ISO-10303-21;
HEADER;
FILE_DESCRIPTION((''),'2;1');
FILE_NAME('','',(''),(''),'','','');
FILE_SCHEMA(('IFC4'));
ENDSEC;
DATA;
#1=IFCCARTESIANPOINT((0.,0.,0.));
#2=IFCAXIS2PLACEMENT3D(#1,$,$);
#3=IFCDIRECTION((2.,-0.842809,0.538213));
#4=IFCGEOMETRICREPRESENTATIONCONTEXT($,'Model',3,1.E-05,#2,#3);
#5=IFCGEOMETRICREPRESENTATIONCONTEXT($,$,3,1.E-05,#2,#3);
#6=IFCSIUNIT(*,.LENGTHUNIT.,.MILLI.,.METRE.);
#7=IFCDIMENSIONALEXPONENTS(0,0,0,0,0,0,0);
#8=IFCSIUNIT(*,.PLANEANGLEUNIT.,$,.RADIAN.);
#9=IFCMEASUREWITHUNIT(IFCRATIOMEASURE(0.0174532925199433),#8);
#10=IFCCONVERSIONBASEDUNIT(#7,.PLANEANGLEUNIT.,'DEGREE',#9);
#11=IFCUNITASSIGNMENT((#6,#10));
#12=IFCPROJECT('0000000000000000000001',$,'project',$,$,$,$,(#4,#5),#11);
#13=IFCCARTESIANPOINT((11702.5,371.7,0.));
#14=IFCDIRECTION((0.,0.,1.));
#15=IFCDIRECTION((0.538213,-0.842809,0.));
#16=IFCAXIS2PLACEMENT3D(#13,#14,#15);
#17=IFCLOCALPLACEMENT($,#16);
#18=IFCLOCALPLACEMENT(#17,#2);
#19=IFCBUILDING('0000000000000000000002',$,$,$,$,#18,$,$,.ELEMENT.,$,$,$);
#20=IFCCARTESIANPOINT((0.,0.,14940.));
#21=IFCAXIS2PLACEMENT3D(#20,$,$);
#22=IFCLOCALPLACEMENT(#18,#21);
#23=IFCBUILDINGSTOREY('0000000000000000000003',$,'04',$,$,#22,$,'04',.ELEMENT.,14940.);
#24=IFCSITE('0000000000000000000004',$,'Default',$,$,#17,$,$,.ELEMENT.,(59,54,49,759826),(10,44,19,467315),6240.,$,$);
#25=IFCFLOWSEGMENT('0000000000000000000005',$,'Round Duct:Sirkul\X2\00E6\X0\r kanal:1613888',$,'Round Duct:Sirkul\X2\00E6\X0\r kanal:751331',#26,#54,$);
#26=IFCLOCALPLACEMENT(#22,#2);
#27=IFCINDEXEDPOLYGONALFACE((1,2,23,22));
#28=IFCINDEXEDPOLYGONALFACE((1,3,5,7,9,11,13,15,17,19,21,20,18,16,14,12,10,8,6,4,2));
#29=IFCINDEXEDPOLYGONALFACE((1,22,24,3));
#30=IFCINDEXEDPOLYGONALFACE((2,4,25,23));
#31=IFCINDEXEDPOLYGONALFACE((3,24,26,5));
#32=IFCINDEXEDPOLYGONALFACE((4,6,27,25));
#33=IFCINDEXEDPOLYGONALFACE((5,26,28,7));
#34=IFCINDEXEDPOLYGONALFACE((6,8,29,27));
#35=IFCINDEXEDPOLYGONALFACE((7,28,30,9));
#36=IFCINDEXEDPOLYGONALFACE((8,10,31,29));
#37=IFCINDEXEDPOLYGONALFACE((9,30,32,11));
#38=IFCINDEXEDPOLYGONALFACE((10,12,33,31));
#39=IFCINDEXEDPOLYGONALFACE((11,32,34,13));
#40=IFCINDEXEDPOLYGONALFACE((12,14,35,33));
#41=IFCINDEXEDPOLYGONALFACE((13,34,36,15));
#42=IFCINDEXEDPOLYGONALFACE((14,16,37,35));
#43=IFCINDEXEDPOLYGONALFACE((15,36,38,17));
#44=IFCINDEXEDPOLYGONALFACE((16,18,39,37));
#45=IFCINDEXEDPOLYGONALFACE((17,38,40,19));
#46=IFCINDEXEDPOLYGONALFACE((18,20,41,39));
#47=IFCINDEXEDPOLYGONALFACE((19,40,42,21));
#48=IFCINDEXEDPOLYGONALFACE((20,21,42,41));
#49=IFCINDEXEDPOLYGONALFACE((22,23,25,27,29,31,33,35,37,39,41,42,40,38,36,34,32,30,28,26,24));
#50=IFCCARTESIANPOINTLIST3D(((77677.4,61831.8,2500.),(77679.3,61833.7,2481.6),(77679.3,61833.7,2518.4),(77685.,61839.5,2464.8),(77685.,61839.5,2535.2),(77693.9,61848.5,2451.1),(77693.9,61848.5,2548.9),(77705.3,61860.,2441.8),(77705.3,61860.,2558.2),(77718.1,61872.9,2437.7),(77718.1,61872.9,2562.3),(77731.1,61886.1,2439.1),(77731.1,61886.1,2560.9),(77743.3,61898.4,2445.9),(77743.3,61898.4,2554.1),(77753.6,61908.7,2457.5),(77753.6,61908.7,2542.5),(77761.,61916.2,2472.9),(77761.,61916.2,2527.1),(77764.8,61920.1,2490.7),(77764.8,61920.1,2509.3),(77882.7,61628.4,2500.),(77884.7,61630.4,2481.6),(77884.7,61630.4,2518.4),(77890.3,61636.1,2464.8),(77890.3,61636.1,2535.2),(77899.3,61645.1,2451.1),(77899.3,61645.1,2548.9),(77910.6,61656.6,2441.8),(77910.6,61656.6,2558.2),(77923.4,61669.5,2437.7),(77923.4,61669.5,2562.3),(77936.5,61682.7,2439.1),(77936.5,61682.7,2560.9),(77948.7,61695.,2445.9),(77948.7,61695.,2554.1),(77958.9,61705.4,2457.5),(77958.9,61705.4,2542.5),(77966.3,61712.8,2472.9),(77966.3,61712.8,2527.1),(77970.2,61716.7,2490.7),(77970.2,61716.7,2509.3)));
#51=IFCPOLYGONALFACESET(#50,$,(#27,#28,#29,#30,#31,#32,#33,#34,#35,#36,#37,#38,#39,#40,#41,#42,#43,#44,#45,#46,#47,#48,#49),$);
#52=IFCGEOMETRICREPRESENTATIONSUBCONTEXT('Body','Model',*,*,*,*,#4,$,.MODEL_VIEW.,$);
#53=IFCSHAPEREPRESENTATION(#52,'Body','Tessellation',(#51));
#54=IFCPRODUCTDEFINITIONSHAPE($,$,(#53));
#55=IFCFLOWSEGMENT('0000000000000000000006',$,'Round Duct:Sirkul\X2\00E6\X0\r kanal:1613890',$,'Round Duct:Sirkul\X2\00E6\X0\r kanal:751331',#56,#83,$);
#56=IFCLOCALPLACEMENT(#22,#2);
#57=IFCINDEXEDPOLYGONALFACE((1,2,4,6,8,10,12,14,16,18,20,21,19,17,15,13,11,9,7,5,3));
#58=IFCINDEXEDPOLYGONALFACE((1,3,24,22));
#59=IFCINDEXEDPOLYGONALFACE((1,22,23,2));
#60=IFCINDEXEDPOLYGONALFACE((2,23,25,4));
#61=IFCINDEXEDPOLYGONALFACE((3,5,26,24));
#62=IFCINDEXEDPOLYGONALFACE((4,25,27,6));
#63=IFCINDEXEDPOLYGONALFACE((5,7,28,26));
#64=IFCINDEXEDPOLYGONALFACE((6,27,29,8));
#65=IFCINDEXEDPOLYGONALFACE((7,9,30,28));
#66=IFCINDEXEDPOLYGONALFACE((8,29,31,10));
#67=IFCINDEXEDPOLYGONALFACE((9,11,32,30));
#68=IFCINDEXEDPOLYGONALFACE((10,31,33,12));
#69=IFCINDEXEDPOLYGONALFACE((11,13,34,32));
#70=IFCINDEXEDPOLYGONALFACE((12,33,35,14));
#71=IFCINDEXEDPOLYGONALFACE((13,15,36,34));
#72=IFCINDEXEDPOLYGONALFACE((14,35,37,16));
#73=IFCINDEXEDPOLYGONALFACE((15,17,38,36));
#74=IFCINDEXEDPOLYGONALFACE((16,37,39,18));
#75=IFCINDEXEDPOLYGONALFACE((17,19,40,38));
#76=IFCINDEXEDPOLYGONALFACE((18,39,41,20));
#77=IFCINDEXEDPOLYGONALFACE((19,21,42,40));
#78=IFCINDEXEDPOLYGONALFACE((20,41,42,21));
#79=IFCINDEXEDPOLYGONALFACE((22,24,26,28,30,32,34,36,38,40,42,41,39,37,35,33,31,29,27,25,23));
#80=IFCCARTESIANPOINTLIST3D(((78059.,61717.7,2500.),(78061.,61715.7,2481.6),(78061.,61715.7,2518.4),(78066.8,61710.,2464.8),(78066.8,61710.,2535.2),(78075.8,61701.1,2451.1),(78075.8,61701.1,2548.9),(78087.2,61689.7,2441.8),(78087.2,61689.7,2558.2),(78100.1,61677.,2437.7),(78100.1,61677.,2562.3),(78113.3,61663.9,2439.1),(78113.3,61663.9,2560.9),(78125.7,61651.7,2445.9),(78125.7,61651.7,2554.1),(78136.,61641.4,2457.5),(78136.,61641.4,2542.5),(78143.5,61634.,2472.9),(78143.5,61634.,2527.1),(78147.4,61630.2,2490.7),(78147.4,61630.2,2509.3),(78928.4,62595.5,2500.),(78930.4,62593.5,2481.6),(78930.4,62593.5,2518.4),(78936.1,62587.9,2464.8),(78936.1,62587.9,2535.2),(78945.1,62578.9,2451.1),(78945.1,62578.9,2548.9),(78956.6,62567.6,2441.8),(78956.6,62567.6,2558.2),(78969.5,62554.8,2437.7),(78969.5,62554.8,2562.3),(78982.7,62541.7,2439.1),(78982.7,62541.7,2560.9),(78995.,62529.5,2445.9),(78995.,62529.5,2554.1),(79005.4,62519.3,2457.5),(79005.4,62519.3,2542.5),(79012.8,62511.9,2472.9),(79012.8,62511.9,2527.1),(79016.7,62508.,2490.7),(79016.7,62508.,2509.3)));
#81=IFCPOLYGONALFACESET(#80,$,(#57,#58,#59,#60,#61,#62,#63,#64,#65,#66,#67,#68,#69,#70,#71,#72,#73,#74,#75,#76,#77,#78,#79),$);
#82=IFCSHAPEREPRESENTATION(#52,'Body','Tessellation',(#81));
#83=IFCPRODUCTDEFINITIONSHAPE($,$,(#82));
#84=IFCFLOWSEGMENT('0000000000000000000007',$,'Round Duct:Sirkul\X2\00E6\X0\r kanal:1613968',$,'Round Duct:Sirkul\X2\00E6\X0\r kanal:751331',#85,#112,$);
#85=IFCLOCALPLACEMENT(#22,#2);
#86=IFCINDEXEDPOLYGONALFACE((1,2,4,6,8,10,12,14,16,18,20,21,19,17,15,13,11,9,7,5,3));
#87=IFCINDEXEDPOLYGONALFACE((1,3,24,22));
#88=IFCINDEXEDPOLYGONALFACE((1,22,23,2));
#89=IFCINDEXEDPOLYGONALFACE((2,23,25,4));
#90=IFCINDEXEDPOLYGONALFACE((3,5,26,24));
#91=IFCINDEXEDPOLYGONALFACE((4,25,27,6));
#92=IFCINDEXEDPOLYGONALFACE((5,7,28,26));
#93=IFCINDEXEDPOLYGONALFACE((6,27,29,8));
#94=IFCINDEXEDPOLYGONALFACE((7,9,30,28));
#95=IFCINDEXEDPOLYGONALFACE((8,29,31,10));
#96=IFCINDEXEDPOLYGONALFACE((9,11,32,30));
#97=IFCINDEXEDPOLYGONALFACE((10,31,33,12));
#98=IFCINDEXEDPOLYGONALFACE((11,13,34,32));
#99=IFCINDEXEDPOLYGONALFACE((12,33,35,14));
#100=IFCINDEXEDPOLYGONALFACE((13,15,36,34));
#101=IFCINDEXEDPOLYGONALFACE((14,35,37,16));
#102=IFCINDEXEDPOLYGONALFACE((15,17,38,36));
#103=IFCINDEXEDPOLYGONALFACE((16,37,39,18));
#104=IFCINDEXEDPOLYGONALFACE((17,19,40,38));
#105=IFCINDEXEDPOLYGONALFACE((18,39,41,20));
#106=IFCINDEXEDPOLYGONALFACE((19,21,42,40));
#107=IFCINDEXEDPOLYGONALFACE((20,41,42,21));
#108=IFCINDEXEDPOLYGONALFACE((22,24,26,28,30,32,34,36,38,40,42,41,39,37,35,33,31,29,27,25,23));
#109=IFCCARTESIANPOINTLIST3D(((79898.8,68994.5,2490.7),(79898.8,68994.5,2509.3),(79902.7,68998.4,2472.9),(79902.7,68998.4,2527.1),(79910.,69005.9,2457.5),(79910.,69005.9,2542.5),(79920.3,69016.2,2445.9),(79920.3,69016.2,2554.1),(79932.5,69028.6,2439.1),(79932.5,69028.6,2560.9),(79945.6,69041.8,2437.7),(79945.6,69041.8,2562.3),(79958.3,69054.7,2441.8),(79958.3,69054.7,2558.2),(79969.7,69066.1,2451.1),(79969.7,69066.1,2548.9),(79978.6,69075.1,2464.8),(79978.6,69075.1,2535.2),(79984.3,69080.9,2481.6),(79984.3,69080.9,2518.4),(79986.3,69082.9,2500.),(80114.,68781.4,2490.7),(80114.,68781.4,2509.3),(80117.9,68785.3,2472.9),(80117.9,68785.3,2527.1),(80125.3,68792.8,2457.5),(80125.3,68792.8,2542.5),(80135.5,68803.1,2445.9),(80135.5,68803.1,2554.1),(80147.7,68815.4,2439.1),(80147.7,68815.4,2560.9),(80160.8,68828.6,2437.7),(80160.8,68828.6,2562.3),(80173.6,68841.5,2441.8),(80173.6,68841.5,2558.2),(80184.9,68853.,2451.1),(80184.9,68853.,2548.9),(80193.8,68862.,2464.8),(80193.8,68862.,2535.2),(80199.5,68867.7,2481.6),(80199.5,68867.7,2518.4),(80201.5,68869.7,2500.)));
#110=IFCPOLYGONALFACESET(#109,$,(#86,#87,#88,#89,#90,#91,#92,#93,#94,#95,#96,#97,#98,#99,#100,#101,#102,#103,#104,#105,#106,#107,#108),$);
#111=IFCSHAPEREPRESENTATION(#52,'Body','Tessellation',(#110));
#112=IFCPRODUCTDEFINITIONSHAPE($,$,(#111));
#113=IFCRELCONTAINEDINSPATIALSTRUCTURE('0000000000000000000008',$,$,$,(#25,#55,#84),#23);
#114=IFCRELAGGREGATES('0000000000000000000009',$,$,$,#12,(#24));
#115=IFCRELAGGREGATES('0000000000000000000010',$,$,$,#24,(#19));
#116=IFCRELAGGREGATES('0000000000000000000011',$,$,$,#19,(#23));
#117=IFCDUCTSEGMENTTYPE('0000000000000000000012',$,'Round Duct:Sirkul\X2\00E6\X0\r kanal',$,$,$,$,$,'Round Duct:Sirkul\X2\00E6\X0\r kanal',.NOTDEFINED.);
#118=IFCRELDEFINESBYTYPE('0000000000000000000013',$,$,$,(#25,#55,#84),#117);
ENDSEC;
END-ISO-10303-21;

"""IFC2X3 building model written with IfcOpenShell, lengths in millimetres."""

from ifc_helpers import new_model, entity, si_unit, converted_unit, direction, frame, origin, origin_2d_with_axis, place, context, subcontext, project, spatial, circle, extrude, type_object, element, save


model = new_model("IFC2X3")

# Units and contexts
model_context = context("Model", 3, precision=1e-05, world=origin(), true_north=direction((2.0, -0.842809, 0.538213)))
context_of_model = context(None, 3, precision=1e-05, world=origin(), true_north=direction((2.0, -0.842809, 0.538213)))
body_context = subcontext(model_context, "Body", "Model", "MODEL_VIEW")
ifc_project = project(units=[si_unit("LENGTHUNIT", "METRE", prefix="MILLI"), converted_unit("PLANEANGLEUNIT", "DEGREE", entity("IfcRatioMeasure", 0.0174532925199433), si_unit("PLANEANGLEUNIT", "RADIAN"), dimensions=[0, 0, 0, 0, 0, 0, 0])], contexts=[model_context, context_of_model])

# Site, building, storey
site_placement = place(None, frame((11702.5, 371.7, 0.0), z_axis=(0.0, 0.0, 1.0), x_axis=(0.538213, -0.842809, 0.0)))
site = spatial("IfcSite", under=ifc_project, at=site_placement, Name="Default", CompositionType="ELEMENT", RefLatitude=(59, 54, 49, 759826), RefLongitude=(10, 44, 19, 467315), RefElevation=6240.0)
building_placement = place(site_placement, origin())
building = spatial("IfcBuilding", under=site, at=building_placement, CompositionType="ELEMENT")
storey_placement = place(building_placement, frame((0.0, 0.0, 14940.0)))
storey = spatial("IfcBuildingStorey", under=building, at=storey_placement, Name="04", LongName="04", CompositionType="ELEMENT", Elevation=14940.0)

# Flow segments
duct_segment_type = type_object("IfcDuctSegmentType", Name="Round Duct:Sirkulær kanal", ElementType="Round Duct:Sirkulær kanal", PredefinedType="NOTDEFINED")
flow_segment_1_placement = place(storey_placement, origin())
element("IfcFlowSegment", 1, at=flow_segment_1_placement, inside=storey, type_object=duct_segment_type, Name="Round Duct:Sirkulær kanal:1613888", ObjectType="Round Duct:Sirkulær kanal:751331", context=body_context, shape_type="SweptSolid", body=[
    extrude(circle(Radius=62.5, at=origin_2d_with_axis()), frame((77926.7, 61672.8, 2500.0), z_axis=(-0.710528, 0.703669, 0.0), x_axis=(-0.703669, -0.710528, 0.0)), (0.0, 0.0, 1.0), 289.0),
])
flow_segment_2_placement = place(storey_placement, origin())
element("IfcFlowSegment", 2, at=flow_segment_2_placement, inside=storey, type_object=duct_segment_type, Name="Round Duct:Sirkulær kanal:1613890", ObjectType="Round Duct:Sirkulær kanal:751331", context=body_context, shape_type="SweptSolid", body=[
    extrude(circle(Radius=62.5, at=origin_2d_with_axis()), frame((78103.5, 61673.7, 2500.0), z_axis=(0.703669, 0.710528, 0.0), x_axis=(-0.710528, 0.703669, 0.0)), (0.0, 0.0, 1.0), 1235.5),
])
flow_segment_3_placement = place(storey_placement, origin())
element("IfcFlowSegment", 3, at=flow_segment_3_placement, inside=storey, type_object=duct_segment_type, Name="Round Duct:Sirkulær kanal:1613968", ObjectType="Round Duct:Sirkulær kanal:751331", context=body_context, shape_type="SweptSolid", body=[
    extrude(circle(Radius=62.5, at=origin_2d_with_axis()), frame((79942.3, 69038.5, 2500.0), z_axis=(0.710536, -0.70366, 0.0), x_axis=(0.70366, 0.710536, 0.0)), (0.0, 0.0, 1.0), 302.9),
])

save(model, "model.ifc")
